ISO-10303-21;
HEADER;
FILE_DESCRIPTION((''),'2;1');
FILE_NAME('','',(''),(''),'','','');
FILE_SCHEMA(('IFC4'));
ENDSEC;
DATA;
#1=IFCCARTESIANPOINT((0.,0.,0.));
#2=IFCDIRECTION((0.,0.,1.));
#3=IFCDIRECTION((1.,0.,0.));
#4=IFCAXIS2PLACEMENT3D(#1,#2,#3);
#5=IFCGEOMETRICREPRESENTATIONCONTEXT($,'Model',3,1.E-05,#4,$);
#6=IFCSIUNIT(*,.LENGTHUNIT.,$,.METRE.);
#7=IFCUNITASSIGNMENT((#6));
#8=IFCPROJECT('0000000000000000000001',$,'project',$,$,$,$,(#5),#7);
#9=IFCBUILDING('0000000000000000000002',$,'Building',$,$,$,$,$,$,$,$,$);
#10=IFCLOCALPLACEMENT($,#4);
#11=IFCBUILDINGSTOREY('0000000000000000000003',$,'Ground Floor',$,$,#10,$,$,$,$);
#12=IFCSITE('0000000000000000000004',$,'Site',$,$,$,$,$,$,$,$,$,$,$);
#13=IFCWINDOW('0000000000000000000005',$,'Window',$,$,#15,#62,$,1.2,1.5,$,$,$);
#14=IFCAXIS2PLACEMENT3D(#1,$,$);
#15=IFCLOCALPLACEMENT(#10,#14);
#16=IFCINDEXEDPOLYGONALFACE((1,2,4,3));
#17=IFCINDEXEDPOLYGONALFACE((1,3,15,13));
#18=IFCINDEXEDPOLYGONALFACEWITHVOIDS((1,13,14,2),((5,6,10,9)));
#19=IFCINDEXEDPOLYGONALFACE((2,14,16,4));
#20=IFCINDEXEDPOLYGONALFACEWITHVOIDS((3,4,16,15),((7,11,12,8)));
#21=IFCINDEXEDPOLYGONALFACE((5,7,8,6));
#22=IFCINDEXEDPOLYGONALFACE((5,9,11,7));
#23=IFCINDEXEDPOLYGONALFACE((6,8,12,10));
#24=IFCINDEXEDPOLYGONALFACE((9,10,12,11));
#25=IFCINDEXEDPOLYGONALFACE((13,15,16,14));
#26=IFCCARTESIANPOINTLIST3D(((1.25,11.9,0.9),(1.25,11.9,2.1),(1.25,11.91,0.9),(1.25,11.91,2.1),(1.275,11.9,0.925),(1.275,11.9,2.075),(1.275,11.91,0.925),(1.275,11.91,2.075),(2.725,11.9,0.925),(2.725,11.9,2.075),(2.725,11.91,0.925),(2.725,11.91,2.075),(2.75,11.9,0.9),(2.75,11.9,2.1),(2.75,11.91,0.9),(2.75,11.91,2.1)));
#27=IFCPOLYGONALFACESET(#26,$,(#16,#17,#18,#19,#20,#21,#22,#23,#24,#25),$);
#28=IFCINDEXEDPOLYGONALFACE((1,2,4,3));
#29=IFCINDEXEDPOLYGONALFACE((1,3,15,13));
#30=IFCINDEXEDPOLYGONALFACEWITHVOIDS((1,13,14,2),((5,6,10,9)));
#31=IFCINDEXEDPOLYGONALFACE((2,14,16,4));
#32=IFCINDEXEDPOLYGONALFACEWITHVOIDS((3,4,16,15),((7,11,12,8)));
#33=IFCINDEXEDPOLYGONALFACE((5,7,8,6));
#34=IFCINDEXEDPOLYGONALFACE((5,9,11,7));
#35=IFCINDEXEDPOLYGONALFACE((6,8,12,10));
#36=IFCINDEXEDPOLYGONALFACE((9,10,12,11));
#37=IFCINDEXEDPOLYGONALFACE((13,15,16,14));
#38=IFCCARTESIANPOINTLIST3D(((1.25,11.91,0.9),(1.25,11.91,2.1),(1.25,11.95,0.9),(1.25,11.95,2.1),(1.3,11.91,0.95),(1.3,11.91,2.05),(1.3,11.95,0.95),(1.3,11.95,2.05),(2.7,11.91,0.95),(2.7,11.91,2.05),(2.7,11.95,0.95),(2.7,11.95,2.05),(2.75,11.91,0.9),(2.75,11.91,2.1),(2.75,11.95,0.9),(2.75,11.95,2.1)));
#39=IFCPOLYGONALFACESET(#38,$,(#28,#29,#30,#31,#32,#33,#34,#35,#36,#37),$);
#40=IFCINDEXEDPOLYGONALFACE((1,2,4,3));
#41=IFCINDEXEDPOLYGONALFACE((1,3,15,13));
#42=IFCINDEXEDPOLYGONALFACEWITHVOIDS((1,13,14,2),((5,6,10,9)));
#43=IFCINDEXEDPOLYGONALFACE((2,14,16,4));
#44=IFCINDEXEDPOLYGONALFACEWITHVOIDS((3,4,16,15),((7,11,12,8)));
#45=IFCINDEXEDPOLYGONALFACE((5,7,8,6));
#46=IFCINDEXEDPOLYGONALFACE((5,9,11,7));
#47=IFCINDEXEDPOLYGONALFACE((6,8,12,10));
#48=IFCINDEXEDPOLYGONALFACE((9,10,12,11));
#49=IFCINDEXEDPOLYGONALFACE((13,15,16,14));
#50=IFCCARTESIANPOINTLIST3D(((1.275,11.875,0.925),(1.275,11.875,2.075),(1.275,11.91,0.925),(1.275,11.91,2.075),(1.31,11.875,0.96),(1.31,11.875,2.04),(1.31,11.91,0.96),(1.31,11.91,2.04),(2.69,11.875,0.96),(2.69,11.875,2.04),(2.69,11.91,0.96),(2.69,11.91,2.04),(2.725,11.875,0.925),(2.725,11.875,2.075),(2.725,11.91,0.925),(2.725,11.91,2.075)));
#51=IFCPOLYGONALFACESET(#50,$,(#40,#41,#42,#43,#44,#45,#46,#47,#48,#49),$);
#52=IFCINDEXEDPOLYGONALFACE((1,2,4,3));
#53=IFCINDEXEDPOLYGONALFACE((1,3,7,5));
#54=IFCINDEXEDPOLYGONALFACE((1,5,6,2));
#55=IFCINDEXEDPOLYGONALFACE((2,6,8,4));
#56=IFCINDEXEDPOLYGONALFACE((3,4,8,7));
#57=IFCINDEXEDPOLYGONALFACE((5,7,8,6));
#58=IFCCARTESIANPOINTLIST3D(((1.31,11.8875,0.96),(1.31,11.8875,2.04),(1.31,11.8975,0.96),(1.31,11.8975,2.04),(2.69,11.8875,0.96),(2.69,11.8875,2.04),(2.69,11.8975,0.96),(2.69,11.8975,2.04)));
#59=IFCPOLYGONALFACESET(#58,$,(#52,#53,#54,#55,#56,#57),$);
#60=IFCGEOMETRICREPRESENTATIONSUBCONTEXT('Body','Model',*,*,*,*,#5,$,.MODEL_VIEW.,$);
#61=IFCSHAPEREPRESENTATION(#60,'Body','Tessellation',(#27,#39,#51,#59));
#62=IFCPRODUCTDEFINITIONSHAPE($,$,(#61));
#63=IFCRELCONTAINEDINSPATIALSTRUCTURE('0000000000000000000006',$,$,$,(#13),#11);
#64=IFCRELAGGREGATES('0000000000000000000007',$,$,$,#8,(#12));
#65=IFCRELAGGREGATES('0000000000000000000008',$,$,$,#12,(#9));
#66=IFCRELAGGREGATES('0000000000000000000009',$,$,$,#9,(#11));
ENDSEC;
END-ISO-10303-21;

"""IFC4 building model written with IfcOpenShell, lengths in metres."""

from ifc_helpers import new_model, si_unit, frame, origin_with_axes, place, context, subcontext, project, spatial, line, indexed_curve, outline, extrude, element, save


model = new_model("IFC4")

# Units and contexts
model_context = context("Model", 3, precision=1e-05, world=origin_with_axes())
body_context = subcontext(model_context, "Body", "Model", "MODEL_VIEW")
ifc_project = project(units=[si_unit("LENGTHUNIT", "METRE")], contexts=[model_context])

# Site, building, storey
site = spatial("IfcSite", under=ifc_project, Name="Site")
building = spatial("IfcBuilding", under=site, Name="Building")
storey_placement = place(None, origin_with_axes())
storey = spatial("IfcBuildingStorey", under=building, at=storey_placement, Name="Ground Floor")

# Window
window_1_placement = place(storey_placement, frame((2.75, 12.0, 0.9), z_axis=(0.0, 0.0, 1.0), x_axis=(-1.0, 0.0, 0.0)))
element("IfcWindow", 1, at=window_1_placement, inside=storey, Name="Window", OverallHeight=1.2, OverallWidth=1.5, context=body_context, shape_type="SweptSolid", body=[
    extrude(outline(indexed_curve([(0.0, 0.0), (1.5, 0.0), (1.5, 1.2), (0.0, 1.2)], segments=[line(1, 2, 3, 4, 1)]), holes=[indexed_curve([(0.025, 0.025), (1.475, 0.025), (1.475, 1.175), (0.025, 1.175)], segments=[line(1, 2, 3, 4, 1)])]), frame((0.0, 0.09, 0.0), z_axis=(0.0, -1.0, 0.0), x_axis=(1.0, 0.0, 0.0)), (0.0, 0.0, -1.0), 0.01),
    extrude(outline(indexed_curve([(0.0, 0.0), (1.5, 0.0), (1.5, 1.2), (0.0, 1.2)], segments=[line(1, 2, 3, 4, 1)]), holes=[indexed_curve([(0.05, 0.05), (1.45, 0.05), (1.45, 1.15), (0.05, 1.15)], segments=[line(1, 2, 3, 4, 1)])]), frame((0.0, 0.05, 0.0), z_axis=(0.0, -1.0, 0.0), x_axis=(1.0, 0.0, 0.0)), (0.0, 0.0, -1.0), 0.04),
    extrude(outline(indexed_curve([(0.0, 0.0), (1.45, 0.0), (1.45, 1.15), (0.0, 1.15)], segments=[line(1, 2, 3, 4, 1)]), holes=[indexed_curve([(0.035, 0.035), (1.415, 0.035), (1.415, 1.115), (0.035, 1.115)], segments=[line(1, 2, 3, 4, 1)])]), frame((0.025, 0.09, 0.025), z_axis=(0.0, -1.0, 0.0), x_axis=(1.0, 0.0, 0.0)), (0.0, 0.0, -1.0), 0.035),
    extrude(outline(indexed_curve([(0.035, 0.035), (1.415, 0.035), (1.415, 1.115), (0.035, 1.115)], segments=[line(1, 2, 3, 4, 1)])), frame((0.025, 0.1025, 0.025), z_axis=(0.0, -1.0, 0.0), x_axis=(1.0, 0.0, 0.0)), (0.0, 0.0, -1.0), 0.01),
])

save(model, "model.ifc")
